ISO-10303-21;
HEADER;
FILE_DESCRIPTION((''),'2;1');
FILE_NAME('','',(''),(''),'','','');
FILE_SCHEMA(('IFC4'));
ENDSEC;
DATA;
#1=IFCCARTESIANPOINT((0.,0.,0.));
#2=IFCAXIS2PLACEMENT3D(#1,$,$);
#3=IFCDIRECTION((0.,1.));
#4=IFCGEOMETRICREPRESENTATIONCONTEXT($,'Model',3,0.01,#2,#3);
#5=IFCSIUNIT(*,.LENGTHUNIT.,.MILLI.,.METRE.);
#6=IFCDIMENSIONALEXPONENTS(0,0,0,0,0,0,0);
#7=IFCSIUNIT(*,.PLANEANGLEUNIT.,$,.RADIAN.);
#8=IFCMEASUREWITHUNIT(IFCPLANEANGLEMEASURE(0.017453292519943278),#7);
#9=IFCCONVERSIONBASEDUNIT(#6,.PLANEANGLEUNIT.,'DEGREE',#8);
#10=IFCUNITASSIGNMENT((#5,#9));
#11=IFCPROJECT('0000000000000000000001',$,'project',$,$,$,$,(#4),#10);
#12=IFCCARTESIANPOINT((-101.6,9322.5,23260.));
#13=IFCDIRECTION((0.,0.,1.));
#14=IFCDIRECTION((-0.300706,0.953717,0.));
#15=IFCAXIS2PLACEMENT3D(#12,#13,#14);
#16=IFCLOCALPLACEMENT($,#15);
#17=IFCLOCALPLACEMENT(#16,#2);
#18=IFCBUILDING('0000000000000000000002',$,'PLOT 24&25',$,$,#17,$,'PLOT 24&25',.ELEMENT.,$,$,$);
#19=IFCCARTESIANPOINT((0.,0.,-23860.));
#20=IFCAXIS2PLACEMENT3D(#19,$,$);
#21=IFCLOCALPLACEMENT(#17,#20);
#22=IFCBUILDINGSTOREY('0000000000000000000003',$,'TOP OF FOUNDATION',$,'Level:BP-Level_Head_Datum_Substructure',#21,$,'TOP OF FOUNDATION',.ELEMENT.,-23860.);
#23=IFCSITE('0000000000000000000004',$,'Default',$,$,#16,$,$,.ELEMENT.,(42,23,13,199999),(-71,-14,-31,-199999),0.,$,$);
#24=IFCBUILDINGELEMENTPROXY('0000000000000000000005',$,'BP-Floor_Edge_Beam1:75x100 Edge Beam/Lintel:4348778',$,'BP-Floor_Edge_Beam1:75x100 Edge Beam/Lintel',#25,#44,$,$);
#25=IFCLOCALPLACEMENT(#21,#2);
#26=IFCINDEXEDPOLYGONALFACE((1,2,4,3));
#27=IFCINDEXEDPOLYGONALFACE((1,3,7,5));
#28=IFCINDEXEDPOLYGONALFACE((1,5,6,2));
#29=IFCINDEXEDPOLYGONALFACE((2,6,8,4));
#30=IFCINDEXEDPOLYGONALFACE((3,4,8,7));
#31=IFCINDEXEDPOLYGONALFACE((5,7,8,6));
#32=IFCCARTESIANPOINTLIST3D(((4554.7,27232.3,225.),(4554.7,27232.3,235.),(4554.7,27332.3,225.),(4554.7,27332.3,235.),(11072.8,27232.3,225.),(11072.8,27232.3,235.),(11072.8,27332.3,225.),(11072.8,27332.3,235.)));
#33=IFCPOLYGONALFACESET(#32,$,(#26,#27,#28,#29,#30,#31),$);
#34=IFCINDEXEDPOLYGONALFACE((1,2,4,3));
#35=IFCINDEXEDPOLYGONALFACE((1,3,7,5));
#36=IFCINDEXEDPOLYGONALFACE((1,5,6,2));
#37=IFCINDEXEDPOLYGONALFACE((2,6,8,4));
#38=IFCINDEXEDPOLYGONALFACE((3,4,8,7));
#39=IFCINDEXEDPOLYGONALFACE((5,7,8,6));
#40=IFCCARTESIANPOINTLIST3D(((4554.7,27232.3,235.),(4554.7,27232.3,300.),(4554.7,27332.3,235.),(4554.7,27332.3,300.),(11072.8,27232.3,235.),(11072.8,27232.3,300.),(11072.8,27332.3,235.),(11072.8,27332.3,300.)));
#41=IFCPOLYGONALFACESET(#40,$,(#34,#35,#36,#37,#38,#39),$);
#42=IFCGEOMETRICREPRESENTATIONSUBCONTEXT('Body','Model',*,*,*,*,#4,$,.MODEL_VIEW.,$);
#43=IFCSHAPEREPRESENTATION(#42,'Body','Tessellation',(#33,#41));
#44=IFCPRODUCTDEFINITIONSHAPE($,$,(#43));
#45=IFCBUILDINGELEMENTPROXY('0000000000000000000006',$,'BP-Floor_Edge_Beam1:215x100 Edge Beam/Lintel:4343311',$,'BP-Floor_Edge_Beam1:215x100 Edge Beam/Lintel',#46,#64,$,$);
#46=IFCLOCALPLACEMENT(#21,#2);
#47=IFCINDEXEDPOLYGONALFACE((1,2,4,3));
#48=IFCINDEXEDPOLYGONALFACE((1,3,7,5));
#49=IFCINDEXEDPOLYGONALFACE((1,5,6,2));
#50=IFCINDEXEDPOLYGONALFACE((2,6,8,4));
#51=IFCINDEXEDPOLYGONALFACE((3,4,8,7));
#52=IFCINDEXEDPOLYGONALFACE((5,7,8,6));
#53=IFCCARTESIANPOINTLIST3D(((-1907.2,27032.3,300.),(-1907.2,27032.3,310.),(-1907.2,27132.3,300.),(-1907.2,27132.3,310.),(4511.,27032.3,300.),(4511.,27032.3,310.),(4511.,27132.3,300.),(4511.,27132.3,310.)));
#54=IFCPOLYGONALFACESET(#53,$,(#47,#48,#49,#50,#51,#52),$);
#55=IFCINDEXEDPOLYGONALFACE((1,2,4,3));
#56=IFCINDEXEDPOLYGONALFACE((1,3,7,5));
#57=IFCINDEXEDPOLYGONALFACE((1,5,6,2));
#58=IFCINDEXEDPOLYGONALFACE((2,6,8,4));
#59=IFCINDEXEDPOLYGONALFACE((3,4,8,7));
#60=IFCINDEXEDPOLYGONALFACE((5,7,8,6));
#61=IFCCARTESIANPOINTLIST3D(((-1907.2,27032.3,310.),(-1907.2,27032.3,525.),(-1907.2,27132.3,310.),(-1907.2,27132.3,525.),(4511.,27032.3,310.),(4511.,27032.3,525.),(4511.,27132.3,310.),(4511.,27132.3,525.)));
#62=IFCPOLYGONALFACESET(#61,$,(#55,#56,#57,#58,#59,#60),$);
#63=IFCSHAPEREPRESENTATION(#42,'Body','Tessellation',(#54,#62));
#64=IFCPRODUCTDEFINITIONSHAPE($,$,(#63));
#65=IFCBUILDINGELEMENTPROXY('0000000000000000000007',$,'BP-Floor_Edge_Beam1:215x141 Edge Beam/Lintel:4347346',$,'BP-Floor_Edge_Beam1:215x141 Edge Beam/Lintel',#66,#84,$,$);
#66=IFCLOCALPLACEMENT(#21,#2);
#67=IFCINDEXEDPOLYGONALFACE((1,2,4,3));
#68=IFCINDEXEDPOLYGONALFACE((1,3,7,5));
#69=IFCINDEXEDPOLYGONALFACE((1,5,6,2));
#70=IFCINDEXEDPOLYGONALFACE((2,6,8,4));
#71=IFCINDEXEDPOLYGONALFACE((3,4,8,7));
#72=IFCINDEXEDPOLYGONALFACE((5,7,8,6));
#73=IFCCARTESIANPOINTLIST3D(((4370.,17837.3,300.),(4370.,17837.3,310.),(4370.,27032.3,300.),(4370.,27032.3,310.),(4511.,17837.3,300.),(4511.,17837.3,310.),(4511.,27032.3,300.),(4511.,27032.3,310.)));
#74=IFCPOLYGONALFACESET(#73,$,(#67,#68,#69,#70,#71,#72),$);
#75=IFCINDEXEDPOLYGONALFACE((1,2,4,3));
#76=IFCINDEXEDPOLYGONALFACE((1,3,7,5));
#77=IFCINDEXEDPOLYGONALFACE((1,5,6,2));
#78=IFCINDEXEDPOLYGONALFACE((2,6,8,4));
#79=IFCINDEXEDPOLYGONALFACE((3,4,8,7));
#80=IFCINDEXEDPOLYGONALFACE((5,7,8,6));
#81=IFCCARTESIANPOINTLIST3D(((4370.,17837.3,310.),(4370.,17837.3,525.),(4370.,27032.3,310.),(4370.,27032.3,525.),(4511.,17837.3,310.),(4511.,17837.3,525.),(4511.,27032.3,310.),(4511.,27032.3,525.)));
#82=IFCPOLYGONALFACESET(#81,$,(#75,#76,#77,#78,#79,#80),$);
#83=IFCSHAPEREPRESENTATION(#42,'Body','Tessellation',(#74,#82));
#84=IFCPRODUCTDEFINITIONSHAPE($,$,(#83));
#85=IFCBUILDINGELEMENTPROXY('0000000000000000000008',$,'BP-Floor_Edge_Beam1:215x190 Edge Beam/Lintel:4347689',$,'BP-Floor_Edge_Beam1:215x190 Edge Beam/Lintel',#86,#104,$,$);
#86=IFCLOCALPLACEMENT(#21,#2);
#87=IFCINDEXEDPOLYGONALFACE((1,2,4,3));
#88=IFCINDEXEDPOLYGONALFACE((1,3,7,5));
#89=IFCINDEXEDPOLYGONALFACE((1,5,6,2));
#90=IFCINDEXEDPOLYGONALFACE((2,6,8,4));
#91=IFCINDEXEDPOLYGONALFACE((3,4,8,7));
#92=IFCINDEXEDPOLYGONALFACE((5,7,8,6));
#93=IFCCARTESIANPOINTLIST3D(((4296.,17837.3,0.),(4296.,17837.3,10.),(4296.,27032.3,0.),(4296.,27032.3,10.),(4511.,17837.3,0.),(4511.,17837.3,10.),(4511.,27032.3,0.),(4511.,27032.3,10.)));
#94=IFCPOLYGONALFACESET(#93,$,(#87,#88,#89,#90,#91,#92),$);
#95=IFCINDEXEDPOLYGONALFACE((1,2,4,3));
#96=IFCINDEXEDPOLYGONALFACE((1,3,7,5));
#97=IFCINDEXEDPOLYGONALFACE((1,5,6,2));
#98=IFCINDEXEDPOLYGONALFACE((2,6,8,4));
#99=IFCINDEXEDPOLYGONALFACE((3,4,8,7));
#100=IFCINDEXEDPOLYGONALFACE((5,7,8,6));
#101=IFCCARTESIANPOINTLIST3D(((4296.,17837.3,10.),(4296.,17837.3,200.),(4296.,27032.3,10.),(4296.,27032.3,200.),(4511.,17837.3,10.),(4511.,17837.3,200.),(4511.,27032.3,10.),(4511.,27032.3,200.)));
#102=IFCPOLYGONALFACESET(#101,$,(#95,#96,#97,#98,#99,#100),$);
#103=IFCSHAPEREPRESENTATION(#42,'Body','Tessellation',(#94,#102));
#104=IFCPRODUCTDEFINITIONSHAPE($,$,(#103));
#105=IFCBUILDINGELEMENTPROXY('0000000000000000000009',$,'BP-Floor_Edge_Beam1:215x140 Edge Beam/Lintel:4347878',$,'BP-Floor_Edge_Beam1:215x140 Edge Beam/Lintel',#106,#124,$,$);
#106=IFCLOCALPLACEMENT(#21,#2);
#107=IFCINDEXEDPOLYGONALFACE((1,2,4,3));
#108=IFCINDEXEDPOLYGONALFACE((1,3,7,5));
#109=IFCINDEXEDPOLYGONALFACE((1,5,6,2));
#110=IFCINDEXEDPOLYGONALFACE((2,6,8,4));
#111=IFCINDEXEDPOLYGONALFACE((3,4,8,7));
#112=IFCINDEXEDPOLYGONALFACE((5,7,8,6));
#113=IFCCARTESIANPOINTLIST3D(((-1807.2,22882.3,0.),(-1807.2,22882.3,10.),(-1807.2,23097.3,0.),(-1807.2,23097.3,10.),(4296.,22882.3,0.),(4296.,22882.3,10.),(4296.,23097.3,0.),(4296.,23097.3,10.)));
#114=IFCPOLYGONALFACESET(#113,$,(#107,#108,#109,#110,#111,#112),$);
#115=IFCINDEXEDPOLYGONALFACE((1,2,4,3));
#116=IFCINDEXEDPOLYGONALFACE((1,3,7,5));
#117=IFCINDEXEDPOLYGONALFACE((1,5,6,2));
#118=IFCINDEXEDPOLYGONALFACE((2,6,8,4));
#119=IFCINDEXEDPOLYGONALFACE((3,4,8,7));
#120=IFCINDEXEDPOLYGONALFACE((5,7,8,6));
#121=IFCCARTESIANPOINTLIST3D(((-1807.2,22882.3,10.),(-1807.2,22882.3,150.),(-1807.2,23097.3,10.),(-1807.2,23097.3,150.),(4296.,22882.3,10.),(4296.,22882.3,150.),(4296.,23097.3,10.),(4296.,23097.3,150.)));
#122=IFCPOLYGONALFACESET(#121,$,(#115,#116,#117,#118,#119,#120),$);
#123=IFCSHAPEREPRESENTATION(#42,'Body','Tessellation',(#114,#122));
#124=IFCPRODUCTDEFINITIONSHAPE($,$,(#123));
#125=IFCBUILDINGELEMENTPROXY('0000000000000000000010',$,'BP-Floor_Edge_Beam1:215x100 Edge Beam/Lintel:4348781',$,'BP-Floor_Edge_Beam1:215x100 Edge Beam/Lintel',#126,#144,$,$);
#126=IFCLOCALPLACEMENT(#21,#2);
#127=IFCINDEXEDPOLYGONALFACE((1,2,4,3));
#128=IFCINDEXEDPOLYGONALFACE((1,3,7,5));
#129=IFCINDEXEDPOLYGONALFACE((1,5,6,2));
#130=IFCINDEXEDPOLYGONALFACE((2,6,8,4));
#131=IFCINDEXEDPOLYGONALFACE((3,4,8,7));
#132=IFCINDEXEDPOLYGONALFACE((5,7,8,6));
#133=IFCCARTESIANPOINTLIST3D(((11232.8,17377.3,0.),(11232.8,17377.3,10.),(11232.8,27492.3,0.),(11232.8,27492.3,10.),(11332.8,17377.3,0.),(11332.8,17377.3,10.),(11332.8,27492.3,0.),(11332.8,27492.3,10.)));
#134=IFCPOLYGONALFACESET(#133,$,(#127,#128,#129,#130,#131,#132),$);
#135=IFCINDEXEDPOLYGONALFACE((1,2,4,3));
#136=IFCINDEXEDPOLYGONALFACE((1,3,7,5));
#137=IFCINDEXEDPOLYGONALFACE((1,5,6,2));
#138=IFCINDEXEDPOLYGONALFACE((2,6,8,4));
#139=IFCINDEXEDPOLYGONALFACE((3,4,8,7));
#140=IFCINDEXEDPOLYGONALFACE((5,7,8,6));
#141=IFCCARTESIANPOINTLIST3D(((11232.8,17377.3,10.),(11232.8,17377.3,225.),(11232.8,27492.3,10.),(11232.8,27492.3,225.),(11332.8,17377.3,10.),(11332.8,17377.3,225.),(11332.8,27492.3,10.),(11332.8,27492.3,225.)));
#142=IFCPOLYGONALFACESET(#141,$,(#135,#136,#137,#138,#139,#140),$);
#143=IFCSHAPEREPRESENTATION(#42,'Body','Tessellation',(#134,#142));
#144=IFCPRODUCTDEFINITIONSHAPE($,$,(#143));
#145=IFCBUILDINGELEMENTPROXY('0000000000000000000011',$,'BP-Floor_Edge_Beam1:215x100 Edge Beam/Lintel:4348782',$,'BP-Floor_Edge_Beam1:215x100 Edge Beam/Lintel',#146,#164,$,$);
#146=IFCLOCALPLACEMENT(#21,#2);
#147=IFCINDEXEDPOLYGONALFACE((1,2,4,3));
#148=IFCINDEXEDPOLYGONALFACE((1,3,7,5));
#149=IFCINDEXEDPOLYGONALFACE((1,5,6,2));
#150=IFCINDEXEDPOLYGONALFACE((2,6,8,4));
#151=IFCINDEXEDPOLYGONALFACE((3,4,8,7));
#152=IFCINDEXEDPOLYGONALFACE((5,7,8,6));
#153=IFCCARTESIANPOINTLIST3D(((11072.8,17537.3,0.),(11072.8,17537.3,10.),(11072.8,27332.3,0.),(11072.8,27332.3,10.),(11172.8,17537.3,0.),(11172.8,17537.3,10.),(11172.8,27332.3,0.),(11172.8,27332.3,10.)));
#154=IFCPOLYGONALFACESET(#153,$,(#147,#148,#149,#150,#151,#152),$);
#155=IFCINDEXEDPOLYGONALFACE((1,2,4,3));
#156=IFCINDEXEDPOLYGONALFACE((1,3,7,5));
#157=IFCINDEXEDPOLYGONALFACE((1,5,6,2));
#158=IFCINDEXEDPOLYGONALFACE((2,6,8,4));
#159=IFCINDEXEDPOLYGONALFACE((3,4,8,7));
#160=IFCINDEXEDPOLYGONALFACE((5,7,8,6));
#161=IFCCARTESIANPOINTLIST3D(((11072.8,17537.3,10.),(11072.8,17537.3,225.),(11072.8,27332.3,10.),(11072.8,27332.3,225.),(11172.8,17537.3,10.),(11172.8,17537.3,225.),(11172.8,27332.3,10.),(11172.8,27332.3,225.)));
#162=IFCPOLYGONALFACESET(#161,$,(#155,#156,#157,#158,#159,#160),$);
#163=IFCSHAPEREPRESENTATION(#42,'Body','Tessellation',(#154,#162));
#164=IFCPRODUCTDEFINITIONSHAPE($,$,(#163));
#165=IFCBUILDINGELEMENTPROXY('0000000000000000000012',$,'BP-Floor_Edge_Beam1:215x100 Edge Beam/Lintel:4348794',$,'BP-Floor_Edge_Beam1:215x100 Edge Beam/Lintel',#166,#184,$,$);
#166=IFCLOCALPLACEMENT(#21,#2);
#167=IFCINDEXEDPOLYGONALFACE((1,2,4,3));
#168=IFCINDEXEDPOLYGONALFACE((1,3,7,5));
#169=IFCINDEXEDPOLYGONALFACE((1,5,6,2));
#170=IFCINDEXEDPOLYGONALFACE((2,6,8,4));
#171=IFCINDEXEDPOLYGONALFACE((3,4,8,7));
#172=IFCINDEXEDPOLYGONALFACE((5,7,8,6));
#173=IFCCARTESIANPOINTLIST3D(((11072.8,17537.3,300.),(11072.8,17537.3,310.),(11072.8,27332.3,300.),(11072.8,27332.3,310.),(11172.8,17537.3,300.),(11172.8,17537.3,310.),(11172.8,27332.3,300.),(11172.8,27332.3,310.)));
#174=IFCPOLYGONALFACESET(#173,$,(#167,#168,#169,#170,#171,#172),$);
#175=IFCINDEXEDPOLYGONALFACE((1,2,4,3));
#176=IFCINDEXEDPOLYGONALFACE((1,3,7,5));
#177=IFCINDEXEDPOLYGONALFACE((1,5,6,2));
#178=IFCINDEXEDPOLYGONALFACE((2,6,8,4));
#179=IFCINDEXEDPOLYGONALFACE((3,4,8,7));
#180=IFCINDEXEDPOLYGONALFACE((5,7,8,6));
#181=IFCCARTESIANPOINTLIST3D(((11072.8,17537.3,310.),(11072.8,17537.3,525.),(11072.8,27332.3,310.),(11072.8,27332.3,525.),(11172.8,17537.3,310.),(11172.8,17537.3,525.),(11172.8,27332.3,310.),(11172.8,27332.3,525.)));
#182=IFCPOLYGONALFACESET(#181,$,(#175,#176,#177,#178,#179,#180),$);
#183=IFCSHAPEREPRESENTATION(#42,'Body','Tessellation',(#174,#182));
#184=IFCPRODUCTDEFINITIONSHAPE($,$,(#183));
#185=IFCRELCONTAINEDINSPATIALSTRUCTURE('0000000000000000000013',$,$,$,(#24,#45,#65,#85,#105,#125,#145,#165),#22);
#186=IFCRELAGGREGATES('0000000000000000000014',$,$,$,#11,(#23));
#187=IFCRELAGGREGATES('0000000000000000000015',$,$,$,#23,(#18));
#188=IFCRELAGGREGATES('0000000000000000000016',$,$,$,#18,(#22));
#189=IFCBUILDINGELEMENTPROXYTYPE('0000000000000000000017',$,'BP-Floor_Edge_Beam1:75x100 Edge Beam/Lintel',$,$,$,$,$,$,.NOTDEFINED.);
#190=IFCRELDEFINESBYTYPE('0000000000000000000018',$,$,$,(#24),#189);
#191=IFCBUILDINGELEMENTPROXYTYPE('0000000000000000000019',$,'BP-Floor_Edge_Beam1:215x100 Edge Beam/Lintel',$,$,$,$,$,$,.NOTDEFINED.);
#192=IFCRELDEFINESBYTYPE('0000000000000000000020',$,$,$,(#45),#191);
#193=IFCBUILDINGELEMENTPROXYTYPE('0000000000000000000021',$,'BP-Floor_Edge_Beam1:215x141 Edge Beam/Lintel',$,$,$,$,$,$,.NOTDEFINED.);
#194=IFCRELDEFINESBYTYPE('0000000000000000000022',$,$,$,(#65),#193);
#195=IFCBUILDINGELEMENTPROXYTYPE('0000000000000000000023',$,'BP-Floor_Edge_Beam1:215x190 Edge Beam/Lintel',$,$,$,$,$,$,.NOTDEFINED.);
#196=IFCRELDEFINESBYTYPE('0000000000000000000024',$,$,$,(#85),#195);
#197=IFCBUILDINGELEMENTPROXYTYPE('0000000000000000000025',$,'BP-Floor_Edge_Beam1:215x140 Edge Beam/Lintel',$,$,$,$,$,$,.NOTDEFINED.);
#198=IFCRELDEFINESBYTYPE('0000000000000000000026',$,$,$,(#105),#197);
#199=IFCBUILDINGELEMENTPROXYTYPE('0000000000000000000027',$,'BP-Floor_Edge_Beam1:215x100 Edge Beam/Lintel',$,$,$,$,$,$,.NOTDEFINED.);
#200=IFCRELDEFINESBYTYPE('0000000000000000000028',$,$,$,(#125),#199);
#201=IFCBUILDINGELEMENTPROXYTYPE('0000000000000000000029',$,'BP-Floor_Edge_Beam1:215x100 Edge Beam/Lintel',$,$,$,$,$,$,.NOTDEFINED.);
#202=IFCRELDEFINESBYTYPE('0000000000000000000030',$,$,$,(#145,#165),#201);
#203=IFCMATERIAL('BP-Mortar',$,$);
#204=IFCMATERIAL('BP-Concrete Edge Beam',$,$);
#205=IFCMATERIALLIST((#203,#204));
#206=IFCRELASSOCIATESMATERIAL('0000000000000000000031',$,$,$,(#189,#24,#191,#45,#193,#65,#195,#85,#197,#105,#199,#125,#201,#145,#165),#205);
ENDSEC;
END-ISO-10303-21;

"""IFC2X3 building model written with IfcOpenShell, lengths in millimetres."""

from ifc_helpers import new_model, entity, si_unit, converted_unit, direction, frame, frame_2d, origin, origin_2d_with_axis, place, context, subcontext, project, spatial, rectangle, extrude, source, transform, mapped, material, material_list, type_object, type_shapes, element, save


model = new_model("IFC2X3")

# Units and contexts
model_context = context("Model", 3, precision=0.01, world=origin(), true_north=direction((0.0, 1.0)))
body_context = subcontext(model_context, "Body", "Model", "MODEL_VIEW")
ifc_project = project(units=[si_unit("LENGTHUNIT", "METRE", prefix="MILLI"), converted_unit("PLANEANGLEUNIT", "DEGREE", entity("IfcPlaneAngleMeasure", 0.017453292519943278), si_unit("PLANEANGLEUNIT", "RADIAN"), dimensions=[0, 0, 0, 0, 0, 0, 0])], contexts=[model_context])

# Site, building, storey
site_placement = place(None, frame((-101.6, 9322.5, 23260.0), z_axis=(0.0, 0.0, 1.0), x_axis=(-0.300706, 0.953717, 0.0)))
site = spatial("IfcSite", under=ifc_project, at=site_placement, Name="Default", CompositionType="ELEMENT", RefLatitude=(42, 23, 13, 199999), RefLongitude=(-71, -14, -31, -199999), RefElevation=0.0)
building_placement = place(site_placement, origin())
building = spatial("IfcBuilding", under=site, at=building_placement, Name="PLOT 24&25", LongName="PLOT 24&25", CompositionType="ELEMENT")
storey_placement = place(building_placement, frame((0.0, 0.0, -23860.0)))
storey = spatial("IfcBuildingStorey", under=building, at=storey_placement, Name="TOP OF FOUNDATION", ObjectType="Level:BP-Level_Head_Datum_Substructure", LongName="TOP OF FOUNDATION", CompositionType="ELEMENT", Elevation=-23860.0)

# Building element proxies
ifc_material_1 = material(Name="BP-Mortar")
ifc_material_2 = material(Name="BP-Concrete Edge Beam")
ifc_material_list = material_list([ifc_material_1, ifc_material_2])
building_element_proxy_type_1 = type_object("IfcBuildingElementProxyType", Name="BP-Floor_Edge_Beam1:75x100 Edge Beam/Lintel", PredefinedType="NOTDEFINED", material=ifc_material_list)
shared_shape_1 = source(origin(), body_context, "Body", "SweptSolid", [
    extrude(rectangle(XDim=100.0, YDim=6518.2, at=frame_2d((0.0, 0.0), x_axis=(1.0, 0.0))), frame((0.0, 0.0, 0.0), z_axis=(0.0, 0.0, 1.0), x_axis=(0.0, 1.0, 0.0)), (0.0, 0.0, 1.0), 10.0),
    extrude(rectangle(XDim=100.0, YDim=6518.2, at=origin_2d_with_axis()), frame((0.0, 0.0, 10.0), z_axis=(0.0, 0.0, 1.0), x_axis=(0.0, 1.0, 0.0)), (0.0, 0.0, 1.0), 65.0),
])
type_shapes(building_element_proxy_type_1, [shared_shape_1])
proxy_1_placement = place(storey_placement, frame((7813.8, 27282.3, 225.0), z_axis=(0.0, 0.0, 1.0), x_axis=(-1.0, 0.0, 0.0)))
element("IfcBuildingElementProxy", 1, at=proxy_1_placement, inside=storey, type_object=building_element_proxy_type_1, material=ifc_material_list, Name="BP-Floor_Edge_Beam1:75x100 Edge Beam/Lintel:4348778", ObjectType="BP-Floor_Edge_Beam1:75x100 Edge Beam/Lintel", context=body_context, shape_type="MappedRepresentation", body=[
    mapped(shared_shape_1, transform((0.0, 0.0, 0.0), scale=1.0)),
])
building_element_proxy_type_2 = type_object("IfcBuildingElementProxyType", Name="BP-Floor_Edge_Beam1:215x100 Edge Beam/Lintel", PredefinedType="NOTDEFINED", material=ifc_material_list)
shared_shape_2 = source(origin(), body_context, "Body", "SweptSolid", [
    extrude(rectangle(XDim=100.0, YDim=6418.2, at=frame_2d((0.0, 0.0), x_axis=(1.0, 0.0))), frame((0.0, 0.0, 0.0), z_axis=(0.0, 0.0, 1.0), x_axis=(0.0, 1.0, 0.0)), (0.0, 0.0, 1.0), 10.0),
    extrude(rectangle(XDim=100.0, YDim=6418.2, at=origin_2d_with_axis()), frame((0.0, 0.0, 10.0), z_axis=(0.0, 0.0, 1.0), x_axis=(0.0, 1.0, 0.0)), (0.0, 0.0, 1.0), 215.0),
])
type_shapes(building_element_proxy_type_2, [shared_shape_2])
proxy_2_placement = place(storey_placement, frame((1301.9, 27082.3, 300.0)))
element("IfcBuildingElementProxy", 2, at=proxy_2_placement, inside=storey, type_object=building_element_proxy_type_2, material=ifc_material_list, Name="BP-Floor_Edge_Beam1:215x100 Edge Beam/Lintel:4343311", ObjectType="BP-Floor_Edge_Beam1:215x100 Edge Beam/Lintel", context=body_context, shape_type="MappedRepresentation", body=[
    mapped(shared_shape_2, transform((0.0, 0.0, 0.0), scale=1.0)),
])
building_element_proxy_type_3 = type_object("IfcBuildingElementProxyType", Name="BP-Floor_Edge_Beam1:215x141 Edge Beam/Lintel", PredefinedType="NOTDEFINED", material=ifc_material_list)
shared_shape_3 = source(origin(), body_context, "Body", "SweptSolid", [
    extrude(rectangle(XDim=9195.0, YDim=141.0, at=origin_2d_with_axis()), frame((0.0, 0.0, 0.0), z_axis=(0.0, 0.0, 1.0), x_axis=(-1.0, 0.0, 0.0)), (0.0, 0.0, 1.0), 10.0),
    extrude(rectangle(XDim=9195.0, YDim=141.0, at=origin_2d_with_axis()), frame((0.0, 0.0, 10.0), z_axis=(0.0, 0.0, 1.0), x_axis=(-1.0, 0.0, 0.0)), (0.0, 0.0, 1.0), 215.0),
])
type_shapes(building_element_proxy_type_3, [shared_shape_3])
proxy_3_placement = place(storey_placement, frame((4440.5, 22434.8, 300.0), z_axis=(0.0, 0.0, 1.0), x_axis=(0.0, 1.0, 0.0)))
element("IfcBuildingElementProxy", 3, at=proxy_3_placement, inside=storey, type_object=building_element_proxy_type_3, material=ifc_material_list, Name="BP-Floor_Edge_Beam1:215x141 Edge Beam/Lintel:4347346", ObjectType="BP-Floor_Edge_Beam1:215x141 Edge Beam/Lintel", context=body_context, shape_type="MappedRepresentation", body=[
    mapped(shared_shape_3, transform((0.0, 0.0, 0.0), scale=1.0)),
])
building_element_proxy_type_4 = type_object("IfcBuildingElementProxyType", Name="BP-Floor_Edge_Beam1:215x190 Edge Beam/Lintel", PredefinedType="NOTDEFINED", material=ifc_material_list)
shared_shape_4 = source(origin(), body_context, "Body", "SweptSolid", [
    extrude(rectangle(XDim=9195.0, YDim=215.0, at=origin_2d_with_axis()), frame((0.0, 0.0, 0.0), z_axis=(0.0, 0.0, 1.0), x_axis=(-1.0, 0.0, 0.0)), (0.0, 0.0, 1.0), 10.0),
    extrude(rectangle(XDim=9195.0, YDim=215.0, at=origin_2d_with_axis()), frame((0.0, 0.0, 10.0), z_axis=(0.0, 0.0, 1.0), x_axis=(-1.0, 0.0, 0.0)), (0.0, 0.0, 1.0), 190.0),
])
type_shapes(building_element_proxy_type_4, [shared_shape_4])
proxy_4_placement = place(storey_placement, frame((4403.5, 22434.8, 0.0), z_axis=(0.0, 0.0, 1.0), x_axis=(0.0, 1.0, 0.0)))
element("IfcBuildingElementProxy", 4, at=proxy_4_placement, inside=storey, type_object=building_element_proxy_type_4, material=ifc_material_list, Name="BP-Floor_Edge_Beam1:215x190 Edge Beam/Lintel:4347689", ObjectType="BP-Floor_Edge_Beam1:215x190 Edge Beam/Lintel", context=body_context, shape_type="MappedRepresentation", body=[
    mapped(shared_shape_4, transform((0.0, 0.0, 0.0), scale=1.0)),
])
building_element_proxy_type_5 = type_object("IfcBuildingElementProxyType", Name="BP-Floor_Edge_Beam1:215x140 Edge Beam/Lintel", PredefinedType="NOTDEFINED", material=ifc_material_list)
shared_shape_5 = source(origin(), body_context, "Body", "SweptSolid", [
    extrude(rectangle(XDim=215.0, YDim=6103.2, at=origin_2d_with_axis()), frame((0.0, 0.0, 0.0), z_axis=(0.0, 0.0, 1.0), x_axis=(0.0, 1.0, 0.0)), (0.0, 0.0, 1.0), 10.0),
    extrude(rectangle(XDim=215.0, YDim=6103.2, at=origin_2d_with_axis()), frame((0.0, 0.0, 10.0), z_axis=(0.0, 0.0, 1.0), x_axis=(0.0, 1.0, 0.0)), (0.0, 0.0, 1.0), 140.0),
])
type_shapes(building_element_proxy_type_5, [shared_shape_5])
proxy_5_placement = place(storey_placement, frame((1244.4, 22989.8, 0.0)))
element("IfcBuildingElementProxy", 5, at=proxy_5_placement, inside=storey, type_object=building_element_proxy_type_5, material=ifc_material_list, Name="BP-Floor_Edge_Beam1:215x140 Edge Beam/Lintel:4347878", ObjectType="BP-Floor_Edge_Beam1:215x140 Edge Beam/Lintel", context=body_context, shape_type="MappedRepresentation", body=[
    mapped(shared_shape_5, transform((0.0, 0.0, 0.0), scale=1.0)),
])
building_element_proxy_type_6 = type_object("IfcBuildingElementProxyType", Name="BP-Floor_Edge_Beam1:215x100 Edge Beam/Lintel", PredefinedType="NOTDEFINED", material=ifc_material_list)
shared_shape_6 = source(origin(), body_context, "Body", "SweptSolid", [
    extrude(rectangle(XDim=100.0, YDim=10115.0, at=frame_2d((0.0, 0.0), x_axis=(1.0, 0.0))), frame((0.0, 0.0, 0.0), z_axis=(0.0, 0.0, 1.0), x_axis=(0.0, 1.0, 0.0)), (0.0, 0.0, 1.0), 10.0),
    extrude(rectangle(XDim=100.0, YDim=10115.0, at=origin_2d_with_axis()), frame((0.0, 0.0, 10.0), z_axis=(0.0, 0.0, 1.0), x_axis=(0.0, 1.0, 0.0)), (0.0, 0.0, 1.0), 215.0),
])
type_shapes(building_element_proxy_type_6, [shared_shape_6])
proxy_6_placement = place(storey_placement, frame((11282.8, 22434.8, 0.0), z_axis=(0.0, 0.0, 1.0), x_axis=(0.0, 1.0, 0.0)))
element("IfcBuildingElementProxy", 6, at=proxy_6_placement, inside=storey, type_object=building_element_proxy_type_6, material=ifc_material_list, Name="BP-Floor_Edge_Beam1:215x100 Edge Beam/Lintel:4348781", ObjectType="BP-Floor_Edge_Beam1:215x100 Edge Beam/Lintel", context=body_context, shape_type="MappedRepresentation", body=[
    mapped(shared_shape_6, transform((0.0, 0.0, 0.0), scale=1.0)),
])
building_element_proxy_type_7 = type_object("IfcBuildingElementProxyType", Name="BP-Floor_Edge_Beam1:215x100 Edge Beam/Lintel", PredefinedType="NOTDEFINED", material=ifc_material_list)
shared_shape_7 = source(origin(), body_context, "Body", "SweptSolid", [
    extrude(rectangle(XDim=100.0, YDim=9795.0, at=frame_2d((0.0, 0.0), x_axis=(1.0, 0.0))), frame((0.0, 0.0, 0.0), z_axis=(0.0, 0.0, 1.0), x_axis=(0.0, 1.0, 0.0)), (0.0, 0.0, 1.0), 10.0),
    extrude(rectangle(XDim=100.0, YDim=9795.0, at=origin_2d_with_axis()), frame((0.0, 0.0, 10.0), z_axis=(0.0, 0.0, 1.0), x_axis=(0.0, 1.0, 0.0)), (0.0, 0.0, 1.0), 215.0),
])
type_shapes(building_element_proxy_type_7, [shared_shape_7])
for number, where, z_axis, x_axis, name in (
    (7, (11122.8, 22434.8, 0.0), (0.0, 0.0, 1.0), (0.0, 1.0, 0.0), "BP-Floor_Edge_Beam1:215x100 Edge Beam/Lintel:4348782"),
    (8, (11122.8, 22434.8, 300.0), (0.0, 0.0, 1.0), (0.0, 1.0, 0.0), "BP-Floor_Edge_Beam1:215x100 Edge Beam/Lintel:4348794"),
):
    element("IfcBuildingElementProxy", number, at=place(storey_placement, frame(where, z_axis=z_axis, x_axis=x_axis)), inside=storey, type_object=building_element_proxy_type_7, material=ifc_material_list, Name=name, ObjectType="BP-Floor_Edge_Beam1:215x100 Edge Beam/Lintel", context=body_context, shape_type="MappedRepresentation", body=[
        mapped(shared_shape_7, transform((0.0, 0.0, 0.0), scale=1.0)),
    ])

save(model, "model.ifc")
